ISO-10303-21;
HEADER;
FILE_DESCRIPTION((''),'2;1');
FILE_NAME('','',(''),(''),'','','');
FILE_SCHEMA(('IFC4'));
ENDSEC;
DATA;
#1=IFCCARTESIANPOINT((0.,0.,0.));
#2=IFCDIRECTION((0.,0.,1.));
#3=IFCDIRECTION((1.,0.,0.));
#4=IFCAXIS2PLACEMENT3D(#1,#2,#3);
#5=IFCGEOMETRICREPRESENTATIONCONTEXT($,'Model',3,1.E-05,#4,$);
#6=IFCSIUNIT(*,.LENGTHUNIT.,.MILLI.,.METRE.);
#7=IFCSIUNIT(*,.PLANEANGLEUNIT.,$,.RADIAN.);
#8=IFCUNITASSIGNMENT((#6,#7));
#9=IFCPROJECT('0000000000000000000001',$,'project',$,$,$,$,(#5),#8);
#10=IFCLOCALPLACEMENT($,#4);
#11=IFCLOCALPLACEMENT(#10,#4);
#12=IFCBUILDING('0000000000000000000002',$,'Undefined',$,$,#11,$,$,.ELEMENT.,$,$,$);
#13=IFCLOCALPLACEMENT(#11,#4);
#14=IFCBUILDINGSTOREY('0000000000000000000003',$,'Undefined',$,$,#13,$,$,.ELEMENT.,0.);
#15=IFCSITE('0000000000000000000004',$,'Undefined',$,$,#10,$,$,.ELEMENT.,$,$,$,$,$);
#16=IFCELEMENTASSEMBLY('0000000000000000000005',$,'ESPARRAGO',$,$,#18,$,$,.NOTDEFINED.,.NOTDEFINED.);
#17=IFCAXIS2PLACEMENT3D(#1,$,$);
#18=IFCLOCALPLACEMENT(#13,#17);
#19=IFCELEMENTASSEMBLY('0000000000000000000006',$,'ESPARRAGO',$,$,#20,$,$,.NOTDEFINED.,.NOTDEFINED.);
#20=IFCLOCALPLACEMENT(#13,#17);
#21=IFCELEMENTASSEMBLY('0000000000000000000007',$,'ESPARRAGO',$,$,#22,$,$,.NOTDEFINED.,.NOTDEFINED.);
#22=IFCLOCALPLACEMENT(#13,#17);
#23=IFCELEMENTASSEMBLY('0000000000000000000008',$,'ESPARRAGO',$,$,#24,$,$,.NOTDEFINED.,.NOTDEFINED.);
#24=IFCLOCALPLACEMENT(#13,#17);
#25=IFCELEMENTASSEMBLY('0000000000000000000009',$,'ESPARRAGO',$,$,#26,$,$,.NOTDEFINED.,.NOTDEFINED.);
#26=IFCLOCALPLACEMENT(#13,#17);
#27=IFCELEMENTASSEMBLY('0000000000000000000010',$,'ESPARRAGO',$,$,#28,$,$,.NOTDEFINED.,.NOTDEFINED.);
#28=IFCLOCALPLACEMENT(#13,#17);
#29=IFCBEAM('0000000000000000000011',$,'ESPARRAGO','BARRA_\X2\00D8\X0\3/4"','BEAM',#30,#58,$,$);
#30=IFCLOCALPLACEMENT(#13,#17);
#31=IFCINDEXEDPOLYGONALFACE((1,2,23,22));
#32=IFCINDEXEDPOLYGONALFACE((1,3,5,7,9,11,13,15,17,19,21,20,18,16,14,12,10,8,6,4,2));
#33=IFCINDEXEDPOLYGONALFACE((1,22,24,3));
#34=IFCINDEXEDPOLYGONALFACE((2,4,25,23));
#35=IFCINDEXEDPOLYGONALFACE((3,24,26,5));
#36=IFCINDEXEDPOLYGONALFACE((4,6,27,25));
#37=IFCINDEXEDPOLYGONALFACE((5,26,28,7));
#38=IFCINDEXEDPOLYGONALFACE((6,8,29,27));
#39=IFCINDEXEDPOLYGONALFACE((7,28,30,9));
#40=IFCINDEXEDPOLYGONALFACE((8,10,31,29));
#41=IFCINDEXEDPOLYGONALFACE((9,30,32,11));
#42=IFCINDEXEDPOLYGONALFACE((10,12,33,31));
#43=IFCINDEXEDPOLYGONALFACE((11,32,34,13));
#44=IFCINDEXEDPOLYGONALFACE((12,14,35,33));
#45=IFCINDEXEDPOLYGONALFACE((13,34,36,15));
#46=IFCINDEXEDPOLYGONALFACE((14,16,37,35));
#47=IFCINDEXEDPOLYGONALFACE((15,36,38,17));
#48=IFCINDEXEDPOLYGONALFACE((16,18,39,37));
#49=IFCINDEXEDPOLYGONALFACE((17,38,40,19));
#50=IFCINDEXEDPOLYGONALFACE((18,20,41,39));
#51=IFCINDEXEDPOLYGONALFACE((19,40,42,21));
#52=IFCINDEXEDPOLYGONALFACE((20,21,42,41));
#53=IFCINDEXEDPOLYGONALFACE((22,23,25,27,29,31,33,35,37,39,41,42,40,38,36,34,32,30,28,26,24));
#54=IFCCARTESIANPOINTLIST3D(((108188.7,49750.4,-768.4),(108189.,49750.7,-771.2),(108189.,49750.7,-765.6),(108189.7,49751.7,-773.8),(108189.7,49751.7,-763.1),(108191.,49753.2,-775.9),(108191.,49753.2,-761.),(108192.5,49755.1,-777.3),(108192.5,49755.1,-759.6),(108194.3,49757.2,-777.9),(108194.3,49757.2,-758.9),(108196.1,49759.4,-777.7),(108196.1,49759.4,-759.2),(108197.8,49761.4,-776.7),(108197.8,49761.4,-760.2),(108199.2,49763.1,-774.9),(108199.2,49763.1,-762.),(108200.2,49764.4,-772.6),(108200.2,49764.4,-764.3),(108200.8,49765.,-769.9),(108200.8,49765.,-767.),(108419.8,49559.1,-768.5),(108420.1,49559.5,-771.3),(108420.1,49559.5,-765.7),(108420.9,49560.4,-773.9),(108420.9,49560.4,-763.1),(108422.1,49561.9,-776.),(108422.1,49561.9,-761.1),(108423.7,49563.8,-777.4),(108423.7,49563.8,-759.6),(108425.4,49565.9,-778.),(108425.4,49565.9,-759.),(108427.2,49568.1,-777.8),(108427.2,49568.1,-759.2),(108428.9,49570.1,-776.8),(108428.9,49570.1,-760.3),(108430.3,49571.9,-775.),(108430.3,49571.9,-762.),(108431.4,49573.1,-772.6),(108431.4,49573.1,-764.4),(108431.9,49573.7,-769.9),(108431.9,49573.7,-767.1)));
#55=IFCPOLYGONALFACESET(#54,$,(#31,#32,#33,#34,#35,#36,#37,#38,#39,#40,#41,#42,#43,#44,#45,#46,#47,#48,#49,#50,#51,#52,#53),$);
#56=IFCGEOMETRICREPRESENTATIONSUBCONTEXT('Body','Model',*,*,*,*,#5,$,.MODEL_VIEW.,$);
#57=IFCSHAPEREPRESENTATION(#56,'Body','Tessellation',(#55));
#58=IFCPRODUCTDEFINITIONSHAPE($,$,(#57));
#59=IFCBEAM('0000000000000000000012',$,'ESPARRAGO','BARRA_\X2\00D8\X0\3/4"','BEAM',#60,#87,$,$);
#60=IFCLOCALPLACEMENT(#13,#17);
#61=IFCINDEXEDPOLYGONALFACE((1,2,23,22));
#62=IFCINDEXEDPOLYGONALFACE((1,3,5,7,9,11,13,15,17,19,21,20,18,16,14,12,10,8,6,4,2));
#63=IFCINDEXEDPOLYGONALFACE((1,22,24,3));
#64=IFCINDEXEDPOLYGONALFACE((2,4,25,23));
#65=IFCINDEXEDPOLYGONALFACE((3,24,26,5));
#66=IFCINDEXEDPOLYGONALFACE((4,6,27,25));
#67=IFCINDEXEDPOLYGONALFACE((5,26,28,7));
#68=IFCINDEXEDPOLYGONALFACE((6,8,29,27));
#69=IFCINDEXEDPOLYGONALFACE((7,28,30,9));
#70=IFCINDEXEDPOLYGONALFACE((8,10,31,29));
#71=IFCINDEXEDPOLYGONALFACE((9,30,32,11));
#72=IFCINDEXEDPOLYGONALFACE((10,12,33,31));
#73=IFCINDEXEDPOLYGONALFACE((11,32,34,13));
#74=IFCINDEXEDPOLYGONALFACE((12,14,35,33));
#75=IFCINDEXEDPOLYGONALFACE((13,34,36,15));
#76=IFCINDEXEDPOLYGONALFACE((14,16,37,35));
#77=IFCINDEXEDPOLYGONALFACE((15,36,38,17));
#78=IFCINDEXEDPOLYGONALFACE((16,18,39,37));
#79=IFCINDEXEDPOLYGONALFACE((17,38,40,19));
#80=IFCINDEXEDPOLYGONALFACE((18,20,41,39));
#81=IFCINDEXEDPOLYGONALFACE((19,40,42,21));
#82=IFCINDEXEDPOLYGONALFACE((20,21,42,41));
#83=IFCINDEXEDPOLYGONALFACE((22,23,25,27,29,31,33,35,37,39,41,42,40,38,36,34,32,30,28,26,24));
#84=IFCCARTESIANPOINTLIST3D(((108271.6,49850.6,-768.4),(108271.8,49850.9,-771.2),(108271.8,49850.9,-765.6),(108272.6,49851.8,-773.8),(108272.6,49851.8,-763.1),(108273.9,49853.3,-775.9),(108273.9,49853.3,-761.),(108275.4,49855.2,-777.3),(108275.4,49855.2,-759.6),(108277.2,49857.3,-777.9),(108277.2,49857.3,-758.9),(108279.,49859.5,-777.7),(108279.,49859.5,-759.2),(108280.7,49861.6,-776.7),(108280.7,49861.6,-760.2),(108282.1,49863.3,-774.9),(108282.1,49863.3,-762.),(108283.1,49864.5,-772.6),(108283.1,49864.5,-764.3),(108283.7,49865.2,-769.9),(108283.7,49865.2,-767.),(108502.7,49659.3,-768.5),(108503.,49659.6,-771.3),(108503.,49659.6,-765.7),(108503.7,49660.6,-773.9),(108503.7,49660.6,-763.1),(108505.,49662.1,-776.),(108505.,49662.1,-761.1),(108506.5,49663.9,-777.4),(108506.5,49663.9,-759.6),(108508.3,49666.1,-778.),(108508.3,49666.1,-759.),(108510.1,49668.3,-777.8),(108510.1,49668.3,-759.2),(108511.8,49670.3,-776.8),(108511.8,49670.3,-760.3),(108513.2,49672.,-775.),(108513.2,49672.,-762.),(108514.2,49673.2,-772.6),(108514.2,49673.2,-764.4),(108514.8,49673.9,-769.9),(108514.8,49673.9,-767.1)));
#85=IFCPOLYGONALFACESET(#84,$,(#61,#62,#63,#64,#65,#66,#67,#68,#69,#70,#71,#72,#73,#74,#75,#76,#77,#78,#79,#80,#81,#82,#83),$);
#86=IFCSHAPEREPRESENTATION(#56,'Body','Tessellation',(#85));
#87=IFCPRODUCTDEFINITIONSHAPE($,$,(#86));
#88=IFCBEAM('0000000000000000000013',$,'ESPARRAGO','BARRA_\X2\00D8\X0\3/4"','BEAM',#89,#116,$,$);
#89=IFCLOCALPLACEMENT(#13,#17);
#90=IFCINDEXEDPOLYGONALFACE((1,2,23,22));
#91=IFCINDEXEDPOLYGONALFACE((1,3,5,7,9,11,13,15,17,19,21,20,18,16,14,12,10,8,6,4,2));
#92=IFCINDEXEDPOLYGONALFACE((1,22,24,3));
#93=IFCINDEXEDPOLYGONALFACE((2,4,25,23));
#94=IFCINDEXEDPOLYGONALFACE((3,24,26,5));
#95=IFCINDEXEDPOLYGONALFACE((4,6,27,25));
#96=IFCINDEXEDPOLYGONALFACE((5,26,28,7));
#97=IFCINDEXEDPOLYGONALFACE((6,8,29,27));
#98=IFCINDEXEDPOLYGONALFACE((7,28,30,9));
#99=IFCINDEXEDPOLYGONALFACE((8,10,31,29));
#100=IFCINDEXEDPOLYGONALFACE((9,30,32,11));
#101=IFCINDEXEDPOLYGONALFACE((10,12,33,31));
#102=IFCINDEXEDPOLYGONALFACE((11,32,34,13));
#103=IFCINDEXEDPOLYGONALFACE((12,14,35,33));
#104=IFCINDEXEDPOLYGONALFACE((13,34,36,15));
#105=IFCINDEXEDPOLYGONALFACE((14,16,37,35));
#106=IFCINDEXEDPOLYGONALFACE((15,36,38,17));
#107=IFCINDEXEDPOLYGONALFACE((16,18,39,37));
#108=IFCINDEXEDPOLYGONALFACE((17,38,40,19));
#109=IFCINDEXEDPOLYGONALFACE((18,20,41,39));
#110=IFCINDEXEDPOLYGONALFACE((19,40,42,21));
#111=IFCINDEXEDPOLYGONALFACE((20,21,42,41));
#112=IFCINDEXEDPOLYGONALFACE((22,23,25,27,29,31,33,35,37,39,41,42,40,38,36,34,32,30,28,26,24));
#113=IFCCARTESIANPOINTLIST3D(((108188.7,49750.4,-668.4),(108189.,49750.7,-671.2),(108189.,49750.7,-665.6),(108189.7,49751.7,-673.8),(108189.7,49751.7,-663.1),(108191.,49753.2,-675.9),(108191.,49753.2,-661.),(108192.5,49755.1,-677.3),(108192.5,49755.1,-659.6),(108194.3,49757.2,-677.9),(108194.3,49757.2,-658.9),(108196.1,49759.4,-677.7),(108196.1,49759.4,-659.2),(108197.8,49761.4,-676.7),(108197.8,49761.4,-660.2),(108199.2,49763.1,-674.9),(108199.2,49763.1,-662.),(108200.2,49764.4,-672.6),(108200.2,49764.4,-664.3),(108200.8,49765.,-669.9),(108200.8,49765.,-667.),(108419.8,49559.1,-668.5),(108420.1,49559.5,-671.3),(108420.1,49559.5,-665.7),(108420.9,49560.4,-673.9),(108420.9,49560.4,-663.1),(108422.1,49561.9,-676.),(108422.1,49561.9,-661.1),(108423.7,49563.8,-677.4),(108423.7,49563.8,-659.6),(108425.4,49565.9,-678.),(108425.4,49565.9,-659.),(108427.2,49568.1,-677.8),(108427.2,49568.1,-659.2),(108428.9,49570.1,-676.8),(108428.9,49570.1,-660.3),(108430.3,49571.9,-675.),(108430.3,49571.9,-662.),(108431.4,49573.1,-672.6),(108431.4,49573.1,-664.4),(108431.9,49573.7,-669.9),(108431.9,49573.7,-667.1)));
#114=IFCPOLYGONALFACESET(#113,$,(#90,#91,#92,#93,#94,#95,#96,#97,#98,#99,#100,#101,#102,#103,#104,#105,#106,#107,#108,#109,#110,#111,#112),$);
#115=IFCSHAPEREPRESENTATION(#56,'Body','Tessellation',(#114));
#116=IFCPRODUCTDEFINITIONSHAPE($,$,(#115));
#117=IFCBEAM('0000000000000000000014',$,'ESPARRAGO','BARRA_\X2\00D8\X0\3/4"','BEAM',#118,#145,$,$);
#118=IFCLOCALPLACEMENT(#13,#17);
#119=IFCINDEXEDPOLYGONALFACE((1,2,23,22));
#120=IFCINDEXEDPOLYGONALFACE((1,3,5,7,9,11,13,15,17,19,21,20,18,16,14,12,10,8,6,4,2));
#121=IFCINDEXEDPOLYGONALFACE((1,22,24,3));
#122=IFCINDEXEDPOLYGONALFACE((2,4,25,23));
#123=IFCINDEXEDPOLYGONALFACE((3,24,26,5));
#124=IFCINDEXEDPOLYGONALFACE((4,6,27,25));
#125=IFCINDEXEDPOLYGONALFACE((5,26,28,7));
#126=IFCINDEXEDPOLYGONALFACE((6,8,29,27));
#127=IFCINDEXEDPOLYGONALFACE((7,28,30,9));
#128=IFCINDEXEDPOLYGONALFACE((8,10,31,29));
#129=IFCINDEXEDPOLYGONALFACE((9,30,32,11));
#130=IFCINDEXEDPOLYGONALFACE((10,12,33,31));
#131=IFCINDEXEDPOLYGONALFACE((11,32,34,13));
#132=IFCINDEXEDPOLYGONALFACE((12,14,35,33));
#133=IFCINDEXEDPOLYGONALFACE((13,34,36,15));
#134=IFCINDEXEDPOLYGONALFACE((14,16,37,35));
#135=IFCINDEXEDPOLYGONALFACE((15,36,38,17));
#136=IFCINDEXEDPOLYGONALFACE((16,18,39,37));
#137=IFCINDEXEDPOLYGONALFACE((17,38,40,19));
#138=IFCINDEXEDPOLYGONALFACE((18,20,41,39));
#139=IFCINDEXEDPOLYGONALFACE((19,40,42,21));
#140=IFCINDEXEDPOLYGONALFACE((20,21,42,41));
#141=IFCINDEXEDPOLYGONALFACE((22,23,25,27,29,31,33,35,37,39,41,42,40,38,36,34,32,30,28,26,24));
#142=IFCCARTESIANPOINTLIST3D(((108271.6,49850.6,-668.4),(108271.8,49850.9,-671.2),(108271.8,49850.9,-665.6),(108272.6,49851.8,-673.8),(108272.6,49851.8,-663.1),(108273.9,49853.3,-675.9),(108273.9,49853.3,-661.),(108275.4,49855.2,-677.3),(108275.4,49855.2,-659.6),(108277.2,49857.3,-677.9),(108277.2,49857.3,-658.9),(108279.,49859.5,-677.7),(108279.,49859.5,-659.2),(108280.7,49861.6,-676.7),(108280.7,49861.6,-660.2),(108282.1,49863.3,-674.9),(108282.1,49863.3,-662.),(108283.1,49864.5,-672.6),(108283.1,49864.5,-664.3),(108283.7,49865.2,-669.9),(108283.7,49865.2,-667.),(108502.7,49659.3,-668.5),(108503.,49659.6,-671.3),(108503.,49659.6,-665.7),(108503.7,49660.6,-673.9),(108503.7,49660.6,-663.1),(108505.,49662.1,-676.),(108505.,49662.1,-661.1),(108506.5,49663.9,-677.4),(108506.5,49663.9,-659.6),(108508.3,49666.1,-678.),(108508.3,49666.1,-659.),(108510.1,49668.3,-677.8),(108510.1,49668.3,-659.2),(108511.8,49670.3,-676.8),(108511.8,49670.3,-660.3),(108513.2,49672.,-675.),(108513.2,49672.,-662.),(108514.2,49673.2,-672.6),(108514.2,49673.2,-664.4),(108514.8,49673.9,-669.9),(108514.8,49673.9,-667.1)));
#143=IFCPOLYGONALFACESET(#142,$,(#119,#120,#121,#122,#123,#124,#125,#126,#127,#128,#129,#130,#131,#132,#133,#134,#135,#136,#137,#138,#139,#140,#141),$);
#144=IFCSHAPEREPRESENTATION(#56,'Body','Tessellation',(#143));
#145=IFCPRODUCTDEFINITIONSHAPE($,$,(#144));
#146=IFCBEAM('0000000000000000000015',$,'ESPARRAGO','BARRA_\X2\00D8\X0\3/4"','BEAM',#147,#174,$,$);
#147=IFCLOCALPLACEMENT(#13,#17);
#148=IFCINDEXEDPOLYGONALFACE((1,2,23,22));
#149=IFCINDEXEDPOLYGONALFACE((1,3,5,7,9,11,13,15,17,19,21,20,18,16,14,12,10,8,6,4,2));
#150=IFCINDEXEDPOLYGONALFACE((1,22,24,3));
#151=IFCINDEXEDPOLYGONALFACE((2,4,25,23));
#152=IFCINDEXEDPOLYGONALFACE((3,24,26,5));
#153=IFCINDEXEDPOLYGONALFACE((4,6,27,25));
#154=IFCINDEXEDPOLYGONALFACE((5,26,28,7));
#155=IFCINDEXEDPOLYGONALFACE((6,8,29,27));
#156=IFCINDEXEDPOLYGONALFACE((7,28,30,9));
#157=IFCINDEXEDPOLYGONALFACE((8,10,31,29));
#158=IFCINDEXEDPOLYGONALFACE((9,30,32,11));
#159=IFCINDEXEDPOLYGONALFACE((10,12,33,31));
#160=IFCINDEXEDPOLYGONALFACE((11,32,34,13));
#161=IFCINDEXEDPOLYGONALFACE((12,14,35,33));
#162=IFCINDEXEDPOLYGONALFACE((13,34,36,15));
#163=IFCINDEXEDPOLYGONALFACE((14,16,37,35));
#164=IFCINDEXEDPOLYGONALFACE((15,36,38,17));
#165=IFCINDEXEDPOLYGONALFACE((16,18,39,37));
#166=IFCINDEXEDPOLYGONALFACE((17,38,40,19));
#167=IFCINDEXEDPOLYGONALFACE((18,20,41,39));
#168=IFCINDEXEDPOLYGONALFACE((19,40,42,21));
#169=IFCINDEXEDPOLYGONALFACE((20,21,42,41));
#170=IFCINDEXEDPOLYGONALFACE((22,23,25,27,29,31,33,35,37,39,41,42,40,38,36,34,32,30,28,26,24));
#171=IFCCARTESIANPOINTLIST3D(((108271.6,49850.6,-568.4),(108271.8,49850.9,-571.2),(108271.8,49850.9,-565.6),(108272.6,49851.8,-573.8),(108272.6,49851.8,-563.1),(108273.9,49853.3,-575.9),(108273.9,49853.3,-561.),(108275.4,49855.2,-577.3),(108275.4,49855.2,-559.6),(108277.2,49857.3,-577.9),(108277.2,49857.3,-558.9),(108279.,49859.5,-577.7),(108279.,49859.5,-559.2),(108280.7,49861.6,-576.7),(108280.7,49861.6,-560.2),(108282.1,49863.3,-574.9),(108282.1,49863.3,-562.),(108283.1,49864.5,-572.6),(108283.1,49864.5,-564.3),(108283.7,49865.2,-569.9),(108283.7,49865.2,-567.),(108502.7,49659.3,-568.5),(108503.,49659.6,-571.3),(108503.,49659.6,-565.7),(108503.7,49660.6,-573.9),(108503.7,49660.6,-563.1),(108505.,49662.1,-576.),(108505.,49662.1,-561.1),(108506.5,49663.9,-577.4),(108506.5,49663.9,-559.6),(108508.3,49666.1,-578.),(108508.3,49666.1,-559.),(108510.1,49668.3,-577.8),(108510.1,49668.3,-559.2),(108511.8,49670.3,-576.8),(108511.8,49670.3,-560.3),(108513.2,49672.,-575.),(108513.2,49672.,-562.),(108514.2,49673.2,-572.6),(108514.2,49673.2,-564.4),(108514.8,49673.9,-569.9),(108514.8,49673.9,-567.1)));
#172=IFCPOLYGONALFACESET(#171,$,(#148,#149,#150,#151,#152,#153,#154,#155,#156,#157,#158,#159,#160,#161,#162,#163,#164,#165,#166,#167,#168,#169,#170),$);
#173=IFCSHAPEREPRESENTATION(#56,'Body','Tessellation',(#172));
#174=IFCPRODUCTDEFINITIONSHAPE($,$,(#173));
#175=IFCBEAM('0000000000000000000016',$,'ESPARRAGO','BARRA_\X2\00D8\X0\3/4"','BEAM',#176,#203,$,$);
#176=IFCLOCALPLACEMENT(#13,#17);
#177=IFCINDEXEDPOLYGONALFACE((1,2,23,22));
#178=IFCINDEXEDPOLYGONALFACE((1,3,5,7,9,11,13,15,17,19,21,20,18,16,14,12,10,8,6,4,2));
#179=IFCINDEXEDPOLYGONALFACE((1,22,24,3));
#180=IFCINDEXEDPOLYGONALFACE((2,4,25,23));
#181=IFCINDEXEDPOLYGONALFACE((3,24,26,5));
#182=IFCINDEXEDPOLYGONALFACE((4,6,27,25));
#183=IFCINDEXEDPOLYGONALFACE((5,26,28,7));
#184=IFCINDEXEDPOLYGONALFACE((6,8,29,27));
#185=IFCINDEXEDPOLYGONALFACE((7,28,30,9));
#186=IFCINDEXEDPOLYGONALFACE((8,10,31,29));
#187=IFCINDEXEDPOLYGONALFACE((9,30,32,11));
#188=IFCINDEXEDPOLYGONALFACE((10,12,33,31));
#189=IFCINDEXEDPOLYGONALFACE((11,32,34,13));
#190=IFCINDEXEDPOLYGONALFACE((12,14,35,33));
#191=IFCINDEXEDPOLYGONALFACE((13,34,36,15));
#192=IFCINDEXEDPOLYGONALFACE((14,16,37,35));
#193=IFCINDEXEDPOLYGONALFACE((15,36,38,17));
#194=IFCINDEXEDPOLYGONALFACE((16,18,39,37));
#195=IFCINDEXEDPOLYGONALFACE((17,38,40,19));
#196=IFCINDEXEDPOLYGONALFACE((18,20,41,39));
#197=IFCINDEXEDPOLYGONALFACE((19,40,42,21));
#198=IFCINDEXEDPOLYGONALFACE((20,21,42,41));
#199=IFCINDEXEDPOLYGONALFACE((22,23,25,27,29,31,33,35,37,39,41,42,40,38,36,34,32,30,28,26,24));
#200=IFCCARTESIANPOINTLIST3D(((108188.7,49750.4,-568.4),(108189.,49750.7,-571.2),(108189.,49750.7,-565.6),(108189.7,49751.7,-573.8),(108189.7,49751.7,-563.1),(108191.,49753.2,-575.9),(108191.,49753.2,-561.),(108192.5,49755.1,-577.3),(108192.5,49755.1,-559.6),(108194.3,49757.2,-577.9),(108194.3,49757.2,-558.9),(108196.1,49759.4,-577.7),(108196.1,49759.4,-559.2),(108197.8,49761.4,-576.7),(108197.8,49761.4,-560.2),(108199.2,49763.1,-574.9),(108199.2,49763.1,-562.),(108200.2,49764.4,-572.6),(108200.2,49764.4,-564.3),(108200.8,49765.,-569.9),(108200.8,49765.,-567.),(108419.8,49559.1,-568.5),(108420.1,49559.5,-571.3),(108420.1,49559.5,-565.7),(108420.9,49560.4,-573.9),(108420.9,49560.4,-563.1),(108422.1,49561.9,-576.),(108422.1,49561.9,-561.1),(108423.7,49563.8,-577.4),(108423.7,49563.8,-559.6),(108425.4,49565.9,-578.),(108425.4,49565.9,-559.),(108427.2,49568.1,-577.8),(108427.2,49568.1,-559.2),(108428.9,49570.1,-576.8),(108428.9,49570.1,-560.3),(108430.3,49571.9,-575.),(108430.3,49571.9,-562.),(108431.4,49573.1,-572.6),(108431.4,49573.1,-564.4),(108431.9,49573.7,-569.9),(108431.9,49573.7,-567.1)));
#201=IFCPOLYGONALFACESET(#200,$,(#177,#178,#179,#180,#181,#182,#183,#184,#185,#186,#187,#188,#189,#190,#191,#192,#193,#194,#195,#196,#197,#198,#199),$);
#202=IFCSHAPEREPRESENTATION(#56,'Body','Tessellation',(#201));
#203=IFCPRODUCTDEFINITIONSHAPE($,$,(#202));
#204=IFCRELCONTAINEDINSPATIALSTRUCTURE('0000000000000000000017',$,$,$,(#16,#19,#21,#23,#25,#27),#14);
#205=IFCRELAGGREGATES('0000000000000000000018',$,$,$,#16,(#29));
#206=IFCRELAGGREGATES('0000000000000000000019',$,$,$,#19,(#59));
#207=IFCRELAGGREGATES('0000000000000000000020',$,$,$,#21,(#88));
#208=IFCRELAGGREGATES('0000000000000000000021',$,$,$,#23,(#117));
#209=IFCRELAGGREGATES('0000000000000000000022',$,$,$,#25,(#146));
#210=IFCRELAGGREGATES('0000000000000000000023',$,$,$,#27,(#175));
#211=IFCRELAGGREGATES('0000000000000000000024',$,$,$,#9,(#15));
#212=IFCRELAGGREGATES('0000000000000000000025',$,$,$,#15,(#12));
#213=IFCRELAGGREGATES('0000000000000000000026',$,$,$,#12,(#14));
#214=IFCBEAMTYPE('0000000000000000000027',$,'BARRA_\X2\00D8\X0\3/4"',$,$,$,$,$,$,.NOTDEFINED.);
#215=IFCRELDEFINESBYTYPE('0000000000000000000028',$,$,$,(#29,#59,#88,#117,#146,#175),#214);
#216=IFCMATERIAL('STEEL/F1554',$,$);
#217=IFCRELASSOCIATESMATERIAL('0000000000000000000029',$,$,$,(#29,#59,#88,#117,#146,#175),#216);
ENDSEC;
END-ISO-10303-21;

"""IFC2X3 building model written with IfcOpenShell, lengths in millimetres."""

from ifc_helpers import new_model, si_unit, frame, origin_with_axes, origin_2d_with_axis, place, context, subcontext, project, spatial, circle, extrude, material, type_object, element, aggregate, save


model = new_model("IFC2X3")

# Units and contexts
model_context = context("Model", 3, precision=1e-05, world=origin_with_axes())
body_context = subcontext(model_context, "Body", "Model", "MODEL_VIEW")
ifc_project = project(units=[si_unit("LENGTHUNIT", "METRE", prefix="MILLI"), si_unit("PLANEANGLEUNIT", "RADIAN")], contexts=[model_context])

# Site, building, storey
site_placement = place(None, origin_with_axes())
site = spatial("IfcSite", under=ifc_project, at=site_placement, Name="Undefined", CompositionType="ELEMENT")
building_placement = place(site_placement, origin_with_axes())
building = spatial("IfcBuilding", under=site, at=building_placement, Name="Undefined", CompositionType="ELEMENT")
storey_placement = place(building_placement, origin_with_axes())
storey = spatial("IfcBuildingStorey", under=building, at=storey_placement, Name="Undefined", CompositionType="ELEMENT", Elevation=0.0)

# Element assemblies
assembly_1_placement = place(storey_placement, origin_with_axes())
assembly_1 = element("IfcElementAssembly", 1, at=assembly_1_placement, inside=storey, Name="ESPARRAGO", AssemblyPlace="NOTDEFINED", PredefinedType="NOTDEFINED")
assembly_2_placement = place(storey_placement, origin_with_axes())
assembly_2 = element("IfcElementAssembly", 2, at=assembly_2_placement, inside=storey, Name="ESPARRAGO", AssemblyPlace="NOTDEFINED", PredefinedType="NOTDEFINED")
assembly_3_placement = place(storey_placement, origin_with_axes())
assembly_3 = element("IfcElementAssembly", 3, at=assembly_3_placement, inside=storey, Name="ESPARRAGO", AssemblyPlace="NOTDEFINED", PredefinedType="NOTDEFINED")
assembly_4_placement = place(storey_placement, origin_with_axes())
assembly_4 = element("IfcElementAssembly", 4, at=assembly_4_placement, inside=storey, Name="ESPARRAGO", AssemblyPlace="NOTDEFINED", PredefinedType="NOTDEFINED")
assembly_5_placement = place(storey_placement, origin_with_axes())
assembly_5 = element("IfcElementAssembly", 5, at=assembly_5_placement, inside=storey, Name="ESPARRAGO", AssemblyPlace="NOTDEFINED", PredefinedType="NOTDEFINED")
assembly_6_placement = place(storey_placement, origin_with_axes())
assembly_6 = element("IfcElementAssembly", 6, at=assembly_6_placement, inside=storey, Name="ESPARRAGO", AssemblyPlace="NOTDEFINED", PredefinedType="NOTDEFINED")

# Beams
ifc_material_1 = material(Name="STEEL/F1554")
beam_type_1 = type_object("IfcBeamType", Name="BARRA_Ø3/4\"", PredefinedType="NOTDEFINED")
beam_1_placement = place(assembly_1_placement, frame((108194.8, 49757.7, -768.4), z_axis=(0.000162, -0.000134, 1.0), x_axis=(0.770403, -0.637558, -0.000211)))
beam_1 = element("IfcBeam", 7, at=beam_1_placement, type_object=beam_type_1, material=ifc_material_1, Name="ESPARRAGO", Description="BARRA_Ø3/4\"", ObjectType="BEAM", context=body_context, shape_type="SweptSolid", body=[
    extrude(circle(Radius=9.5, at=origin_2d_with_axis()), frame((300.0, 0.0, 0.0), z_axis=(-1.0, 0.0, 0.0), x_axis=(0.0, -1.0, 0.0)), (0.0, 0.0, 1.0), 300.0),
])
aggregate(assembly_1, [beam_1])
beam_2_placement = place(assembly_2_placement, frame((108277.6, 49857.9, -768.4), z_axis=(0.000162, -0.000134, 1.0), x_axis=(0.770403, -0.637558, -0.000211)))
beam_2 = element("IfcBeam", 8, at=beam_2_placement, type_object=beam_type_1, material=ifc_material_1, Name="ESPARRAGO", Description="BARRA_Ø3/4\"", ObjectType="BEAM", context=body_context, shape_type="SweptSolid", body=[
    extrude(circle(Radius=9.5, at=origin_2d_with_axis()), frame((300.0, 0.0, 0.0), z_axis=(-1.0, 0.0, 0.0), x_axis=(0.0, -1.0, 0.0)), (0.0, 0.0, 1.0), 300.0),
])
aggregate(assembly_2, [beam_2])
beam_3_placement = place(assembly_3_placement, frame((108194.8, 49757.7, -668.4), z_axis=(0.000162, -0.000134, 1.0), x_axis=(0.770403, -0.637558, -0.000211)))
beam_3 = element("IfcBeam", 9, at=beam_3_placement, type_object=beam_type_1, material=ifc_material_1, Name="ESPARRAGO", Description="BARRA_Ø3/4\"", ObjectType="BEAM", context=body_context, shape_type="SweptSolid", body=[
    extrude(circle(Radius=9.5, at=origin_2d_with_axis()), frame((300.0, 0.0, 0.0), z_axis=(-1.0, 0.0, 0.0), x_axis=(0.0, -1.0, 0.0)), (0.0, 0.0, 1.0), 300.0),
])
aggregate(assembly_3, [beam_3])
beam_4_placement = place(assembly_4_placement, frame((108277.6, 49857.9, -668.4), z_axis=(0.000162, -0.000134, 1.0), x_axis=(0.770403, -0.637558, -0.000211)))
beam_4 = element("IfcBeam", 10, at=beam_4_placement, type_object=beam_type_1, material=ifc_material_1, Name="ESPARRAGO", Description="BARRA_Ø3/4\"", ObjectType="BEAM", context=body_context, shape_type="SweptSolid", body=[
    extrude(circle(Radius=9.5, at=origin_2d_with_axis()), frame((300.0, 0.0, 0.0), z_axis=(-1.0, 0.0, 0.0), x_axis=(0.0, -1.0, 0.0)), (0.0, 0.0, 1.0), 300.0),
])
aggregate(assembly_4, [beam_4])
beam_5_placement = place(assembly_5_placement, frame((108277.6, 49857.9, -568.4), z_axis=(0.000162, -0.000134, 1.0), x_axis=(0.770403, -0.637558, -0.000211)))
beam_5 = element("IfcBeam", 11, at=beam_5_placement, type_object=beam_type_1, material=ifc_material_1, Name="ESPARRAGO", Description="BARRA_Ø3/4\"", ObjectType="BEAM", context=body_context, shape_type="SweptSolid", body=[
    extrude(circle(Radius=9.5, at=origin_2d_with_axis()), frame((300.0, 0.0, 0.0), z_axis=(-1.0, 0.0, 0.0), x_axis=(0.0, -1.0, 0.0)), (0.0, 0.0, 1.0), 300.0),
])
aggregate(assembly_5, [beam_5])
beam_6_placement = place(assembly_6_placement, frame((108194.8, 49757.7, -568.4), z_axis=(0.000162, -0.000134, 1.0), x_axis=(0.770403, -0.637558, -0.000211)))
beam_6 = element("IfcBeam", 12, at=beam_6_placement, type_object=beam_type_1, material=ifc_material_1, Name="ESPARRAGO", Description="BARRA_Ø3/4\"", ObjectType="BEAM", context=body_context, shape_type="SweptSolid", body=[
    extrude(circle(Radius=9.5, at=origin_2d_with_axis()), frame((300.0, 0.0, 0.0), z_axis=(-1.0, 0.0, 0.0), x_axis=(0.0, -1.0, 0.0)), (0.0, 0.0, 1.0), 300.0),
])
aggregate(assembly_6, [beam_6])

save(model, "model.ifc")
